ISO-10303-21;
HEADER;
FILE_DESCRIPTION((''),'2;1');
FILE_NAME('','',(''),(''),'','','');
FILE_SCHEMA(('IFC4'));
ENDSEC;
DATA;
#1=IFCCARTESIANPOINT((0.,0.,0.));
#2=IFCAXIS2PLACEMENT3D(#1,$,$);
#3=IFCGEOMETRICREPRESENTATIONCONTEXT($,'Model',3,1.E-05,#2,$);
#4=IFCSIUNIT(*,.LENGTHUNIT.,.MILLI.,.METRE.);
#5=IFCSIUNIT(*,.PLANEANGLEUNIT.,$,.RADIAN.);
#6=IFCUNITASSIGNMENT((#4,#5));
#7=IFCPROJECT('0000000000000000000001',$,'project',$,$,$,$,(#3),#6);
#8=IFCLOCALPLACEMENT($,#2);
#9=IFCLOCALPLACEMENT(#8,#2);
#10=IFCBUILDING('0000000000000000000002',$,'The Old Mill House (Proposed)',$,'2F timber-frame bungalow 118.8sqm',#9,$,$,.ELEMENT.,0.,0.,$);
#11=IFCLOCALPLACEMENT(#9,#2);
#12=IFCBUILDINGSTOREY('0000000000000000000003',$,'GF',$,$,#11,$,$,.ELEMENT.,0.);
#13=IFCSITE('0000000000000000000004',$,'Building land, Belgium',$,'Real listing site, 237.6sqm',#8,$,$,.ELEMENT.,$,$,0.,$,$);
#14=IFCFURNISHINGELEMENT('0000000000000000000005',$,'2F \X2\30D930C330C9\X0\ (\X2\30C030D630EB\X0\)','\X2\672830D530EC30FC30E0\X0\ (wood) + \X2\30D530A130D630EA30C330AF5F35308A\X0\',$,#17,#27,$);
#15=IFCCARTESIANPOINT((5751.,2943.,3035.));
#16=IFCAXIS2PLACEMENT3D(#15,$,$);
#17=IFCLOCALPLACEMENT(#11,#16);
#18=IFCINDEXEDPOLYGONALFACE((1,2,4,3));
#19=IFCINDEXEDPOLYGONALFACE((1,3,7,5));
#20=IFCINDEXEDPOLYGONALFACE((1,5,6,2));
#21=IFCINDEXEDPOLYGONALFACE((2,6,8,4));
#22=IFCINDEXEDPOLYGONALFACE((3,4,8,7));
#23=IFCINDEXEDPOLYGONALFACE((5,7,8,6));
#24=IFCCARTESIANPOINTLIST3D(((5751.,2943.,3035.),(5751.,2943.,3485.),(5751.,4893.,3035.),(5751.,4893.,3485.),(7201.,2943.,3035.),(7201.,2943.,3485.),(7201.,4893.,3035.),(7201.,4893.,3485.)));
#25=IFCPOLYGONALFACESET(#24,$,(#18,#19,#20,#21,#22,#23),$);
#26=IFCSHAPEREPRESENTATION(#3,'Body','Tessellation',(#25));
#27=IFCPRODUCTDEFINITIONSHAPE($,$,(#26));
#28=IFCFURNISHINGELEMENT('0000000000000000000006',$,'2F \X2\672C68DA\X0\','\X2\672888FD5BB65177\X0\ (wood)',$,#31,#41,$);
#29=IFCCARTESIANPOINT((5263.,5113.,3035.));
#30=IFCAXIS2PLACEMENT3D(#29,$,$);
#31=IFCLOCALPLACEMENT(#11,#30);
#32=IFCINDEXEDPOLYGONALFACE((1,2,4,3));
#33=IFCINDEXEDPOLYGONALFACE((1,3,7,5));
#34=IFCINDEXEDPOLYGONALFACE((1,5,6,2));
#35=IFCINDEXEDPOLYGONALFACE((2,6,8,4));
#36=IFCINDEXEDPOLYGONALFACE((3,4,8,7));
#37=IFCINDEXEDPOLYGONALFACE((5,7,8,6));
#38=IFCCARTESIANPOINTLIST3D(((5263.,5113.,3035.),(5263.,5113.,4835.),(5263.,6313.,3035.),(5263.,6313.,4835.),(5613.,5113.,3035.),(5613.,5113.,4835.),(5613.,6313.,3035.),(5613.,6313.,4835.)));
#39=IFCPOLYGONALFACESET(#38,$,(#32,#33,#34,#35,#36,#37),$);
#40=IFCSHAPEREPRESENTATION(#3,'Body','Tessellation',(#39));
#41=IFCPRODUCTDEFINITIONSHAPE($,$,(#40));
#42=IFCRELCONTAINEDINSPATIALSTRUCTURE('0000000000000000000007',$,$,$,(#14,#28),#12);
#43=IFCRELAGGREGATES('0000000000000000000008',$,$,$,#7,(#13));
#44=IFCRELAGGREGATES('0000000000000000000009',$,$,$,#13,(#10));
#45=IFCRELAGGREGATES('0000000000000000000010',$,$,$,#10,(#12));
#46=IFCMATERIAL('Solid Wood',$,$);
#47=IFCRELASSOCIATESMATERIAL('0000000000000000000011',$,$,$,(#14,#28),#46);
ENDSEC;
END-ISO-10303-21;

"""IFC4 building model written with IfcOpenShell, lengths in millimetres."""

from ifc_helpers import new_model, si_unit, frame, frame_2d, origin, place, context, project, spatial, rectangle, extrude, material, element, save


model = new_model("IFC4")

# Units and contexts
model_context = context("Model", 3, precision=1e-05, world=origin())
ifc_project = project(units=[si_unit("LENGTHUNIT", "METRE", prefix="MILLI"), si_unit("PLANEANGLEUNIT", "RADIAN")], contexts=[model_context])

# Site, building, storey
site_placement = place(None, origin())
site = spatial("IfcSite", under=ifc_project, at=site_placement, Name="Building land, Belgium", ObjectType="Real listing site, 237.6sqm", CompositionType="ELEMENT", RefElevation=0.0)
building_placement = place(site_placement, origin())
building = spatial("IfcBuilding", under=site, at=building_placement, Name="The Old Mill House (Proposed)", ObjectType="2F timber-frame bungalow 118.8sqm", CompositionType="ELEMENT", ElevationOfRefHeight=0.0, ElevationOfTerrain=0.0)
storey_placement = place(building_placement, origin())
storey = spatial("IfcBuildingStorey", under=building, at=storey_placement, Name="GF", CompositionType="ELEMENT", Elevation=0.0)

# Shared definitions
ifc_material_1 = material(Name="Solid Wood")

# Furnishing elements
furnishing_1_placement = place(storey_placement, frame((5751.0, 2943.0, 3035.0)))
element("IfcFurnishingElement", 1, at=furnishing_1_placement, inside=storey, material=ifc_material_1, Name="2F ベッド (ダブル)", Description="木フレーム (wood) + ファブリック張り", context=model_context, shape_type="SweptSolid", body=[
    extrude(rectangle(XDim=1450.0, YDim=1950.0, at=frame_2d((725.0, 975.0))), frame((5751.0, 2943.0, 3035.0)), (0.0, 0.0, 1.0), 450.0),
])
furnishing_2_placement = place(storey_placement, frame((5263.0, 5113.0, 3035.0)))
element("IfcFurnishingElement", 2, at=furnishing_2_placement, inside=storey, material=ifc_material_1, Name="2F 本棚", Description="木製家具 (wood)", context=model_context, shape_type="SweptSolid", body=[
    extrude(rectangle(XDim=350.0, YDim=1200.0, at=frame_2d((175.0, 600.0))), frame((5263.0, 5113.0, 3035.0)), (0.0, 0.0, 1.0), 1800.0),
])

save(model, "model.ifc")
